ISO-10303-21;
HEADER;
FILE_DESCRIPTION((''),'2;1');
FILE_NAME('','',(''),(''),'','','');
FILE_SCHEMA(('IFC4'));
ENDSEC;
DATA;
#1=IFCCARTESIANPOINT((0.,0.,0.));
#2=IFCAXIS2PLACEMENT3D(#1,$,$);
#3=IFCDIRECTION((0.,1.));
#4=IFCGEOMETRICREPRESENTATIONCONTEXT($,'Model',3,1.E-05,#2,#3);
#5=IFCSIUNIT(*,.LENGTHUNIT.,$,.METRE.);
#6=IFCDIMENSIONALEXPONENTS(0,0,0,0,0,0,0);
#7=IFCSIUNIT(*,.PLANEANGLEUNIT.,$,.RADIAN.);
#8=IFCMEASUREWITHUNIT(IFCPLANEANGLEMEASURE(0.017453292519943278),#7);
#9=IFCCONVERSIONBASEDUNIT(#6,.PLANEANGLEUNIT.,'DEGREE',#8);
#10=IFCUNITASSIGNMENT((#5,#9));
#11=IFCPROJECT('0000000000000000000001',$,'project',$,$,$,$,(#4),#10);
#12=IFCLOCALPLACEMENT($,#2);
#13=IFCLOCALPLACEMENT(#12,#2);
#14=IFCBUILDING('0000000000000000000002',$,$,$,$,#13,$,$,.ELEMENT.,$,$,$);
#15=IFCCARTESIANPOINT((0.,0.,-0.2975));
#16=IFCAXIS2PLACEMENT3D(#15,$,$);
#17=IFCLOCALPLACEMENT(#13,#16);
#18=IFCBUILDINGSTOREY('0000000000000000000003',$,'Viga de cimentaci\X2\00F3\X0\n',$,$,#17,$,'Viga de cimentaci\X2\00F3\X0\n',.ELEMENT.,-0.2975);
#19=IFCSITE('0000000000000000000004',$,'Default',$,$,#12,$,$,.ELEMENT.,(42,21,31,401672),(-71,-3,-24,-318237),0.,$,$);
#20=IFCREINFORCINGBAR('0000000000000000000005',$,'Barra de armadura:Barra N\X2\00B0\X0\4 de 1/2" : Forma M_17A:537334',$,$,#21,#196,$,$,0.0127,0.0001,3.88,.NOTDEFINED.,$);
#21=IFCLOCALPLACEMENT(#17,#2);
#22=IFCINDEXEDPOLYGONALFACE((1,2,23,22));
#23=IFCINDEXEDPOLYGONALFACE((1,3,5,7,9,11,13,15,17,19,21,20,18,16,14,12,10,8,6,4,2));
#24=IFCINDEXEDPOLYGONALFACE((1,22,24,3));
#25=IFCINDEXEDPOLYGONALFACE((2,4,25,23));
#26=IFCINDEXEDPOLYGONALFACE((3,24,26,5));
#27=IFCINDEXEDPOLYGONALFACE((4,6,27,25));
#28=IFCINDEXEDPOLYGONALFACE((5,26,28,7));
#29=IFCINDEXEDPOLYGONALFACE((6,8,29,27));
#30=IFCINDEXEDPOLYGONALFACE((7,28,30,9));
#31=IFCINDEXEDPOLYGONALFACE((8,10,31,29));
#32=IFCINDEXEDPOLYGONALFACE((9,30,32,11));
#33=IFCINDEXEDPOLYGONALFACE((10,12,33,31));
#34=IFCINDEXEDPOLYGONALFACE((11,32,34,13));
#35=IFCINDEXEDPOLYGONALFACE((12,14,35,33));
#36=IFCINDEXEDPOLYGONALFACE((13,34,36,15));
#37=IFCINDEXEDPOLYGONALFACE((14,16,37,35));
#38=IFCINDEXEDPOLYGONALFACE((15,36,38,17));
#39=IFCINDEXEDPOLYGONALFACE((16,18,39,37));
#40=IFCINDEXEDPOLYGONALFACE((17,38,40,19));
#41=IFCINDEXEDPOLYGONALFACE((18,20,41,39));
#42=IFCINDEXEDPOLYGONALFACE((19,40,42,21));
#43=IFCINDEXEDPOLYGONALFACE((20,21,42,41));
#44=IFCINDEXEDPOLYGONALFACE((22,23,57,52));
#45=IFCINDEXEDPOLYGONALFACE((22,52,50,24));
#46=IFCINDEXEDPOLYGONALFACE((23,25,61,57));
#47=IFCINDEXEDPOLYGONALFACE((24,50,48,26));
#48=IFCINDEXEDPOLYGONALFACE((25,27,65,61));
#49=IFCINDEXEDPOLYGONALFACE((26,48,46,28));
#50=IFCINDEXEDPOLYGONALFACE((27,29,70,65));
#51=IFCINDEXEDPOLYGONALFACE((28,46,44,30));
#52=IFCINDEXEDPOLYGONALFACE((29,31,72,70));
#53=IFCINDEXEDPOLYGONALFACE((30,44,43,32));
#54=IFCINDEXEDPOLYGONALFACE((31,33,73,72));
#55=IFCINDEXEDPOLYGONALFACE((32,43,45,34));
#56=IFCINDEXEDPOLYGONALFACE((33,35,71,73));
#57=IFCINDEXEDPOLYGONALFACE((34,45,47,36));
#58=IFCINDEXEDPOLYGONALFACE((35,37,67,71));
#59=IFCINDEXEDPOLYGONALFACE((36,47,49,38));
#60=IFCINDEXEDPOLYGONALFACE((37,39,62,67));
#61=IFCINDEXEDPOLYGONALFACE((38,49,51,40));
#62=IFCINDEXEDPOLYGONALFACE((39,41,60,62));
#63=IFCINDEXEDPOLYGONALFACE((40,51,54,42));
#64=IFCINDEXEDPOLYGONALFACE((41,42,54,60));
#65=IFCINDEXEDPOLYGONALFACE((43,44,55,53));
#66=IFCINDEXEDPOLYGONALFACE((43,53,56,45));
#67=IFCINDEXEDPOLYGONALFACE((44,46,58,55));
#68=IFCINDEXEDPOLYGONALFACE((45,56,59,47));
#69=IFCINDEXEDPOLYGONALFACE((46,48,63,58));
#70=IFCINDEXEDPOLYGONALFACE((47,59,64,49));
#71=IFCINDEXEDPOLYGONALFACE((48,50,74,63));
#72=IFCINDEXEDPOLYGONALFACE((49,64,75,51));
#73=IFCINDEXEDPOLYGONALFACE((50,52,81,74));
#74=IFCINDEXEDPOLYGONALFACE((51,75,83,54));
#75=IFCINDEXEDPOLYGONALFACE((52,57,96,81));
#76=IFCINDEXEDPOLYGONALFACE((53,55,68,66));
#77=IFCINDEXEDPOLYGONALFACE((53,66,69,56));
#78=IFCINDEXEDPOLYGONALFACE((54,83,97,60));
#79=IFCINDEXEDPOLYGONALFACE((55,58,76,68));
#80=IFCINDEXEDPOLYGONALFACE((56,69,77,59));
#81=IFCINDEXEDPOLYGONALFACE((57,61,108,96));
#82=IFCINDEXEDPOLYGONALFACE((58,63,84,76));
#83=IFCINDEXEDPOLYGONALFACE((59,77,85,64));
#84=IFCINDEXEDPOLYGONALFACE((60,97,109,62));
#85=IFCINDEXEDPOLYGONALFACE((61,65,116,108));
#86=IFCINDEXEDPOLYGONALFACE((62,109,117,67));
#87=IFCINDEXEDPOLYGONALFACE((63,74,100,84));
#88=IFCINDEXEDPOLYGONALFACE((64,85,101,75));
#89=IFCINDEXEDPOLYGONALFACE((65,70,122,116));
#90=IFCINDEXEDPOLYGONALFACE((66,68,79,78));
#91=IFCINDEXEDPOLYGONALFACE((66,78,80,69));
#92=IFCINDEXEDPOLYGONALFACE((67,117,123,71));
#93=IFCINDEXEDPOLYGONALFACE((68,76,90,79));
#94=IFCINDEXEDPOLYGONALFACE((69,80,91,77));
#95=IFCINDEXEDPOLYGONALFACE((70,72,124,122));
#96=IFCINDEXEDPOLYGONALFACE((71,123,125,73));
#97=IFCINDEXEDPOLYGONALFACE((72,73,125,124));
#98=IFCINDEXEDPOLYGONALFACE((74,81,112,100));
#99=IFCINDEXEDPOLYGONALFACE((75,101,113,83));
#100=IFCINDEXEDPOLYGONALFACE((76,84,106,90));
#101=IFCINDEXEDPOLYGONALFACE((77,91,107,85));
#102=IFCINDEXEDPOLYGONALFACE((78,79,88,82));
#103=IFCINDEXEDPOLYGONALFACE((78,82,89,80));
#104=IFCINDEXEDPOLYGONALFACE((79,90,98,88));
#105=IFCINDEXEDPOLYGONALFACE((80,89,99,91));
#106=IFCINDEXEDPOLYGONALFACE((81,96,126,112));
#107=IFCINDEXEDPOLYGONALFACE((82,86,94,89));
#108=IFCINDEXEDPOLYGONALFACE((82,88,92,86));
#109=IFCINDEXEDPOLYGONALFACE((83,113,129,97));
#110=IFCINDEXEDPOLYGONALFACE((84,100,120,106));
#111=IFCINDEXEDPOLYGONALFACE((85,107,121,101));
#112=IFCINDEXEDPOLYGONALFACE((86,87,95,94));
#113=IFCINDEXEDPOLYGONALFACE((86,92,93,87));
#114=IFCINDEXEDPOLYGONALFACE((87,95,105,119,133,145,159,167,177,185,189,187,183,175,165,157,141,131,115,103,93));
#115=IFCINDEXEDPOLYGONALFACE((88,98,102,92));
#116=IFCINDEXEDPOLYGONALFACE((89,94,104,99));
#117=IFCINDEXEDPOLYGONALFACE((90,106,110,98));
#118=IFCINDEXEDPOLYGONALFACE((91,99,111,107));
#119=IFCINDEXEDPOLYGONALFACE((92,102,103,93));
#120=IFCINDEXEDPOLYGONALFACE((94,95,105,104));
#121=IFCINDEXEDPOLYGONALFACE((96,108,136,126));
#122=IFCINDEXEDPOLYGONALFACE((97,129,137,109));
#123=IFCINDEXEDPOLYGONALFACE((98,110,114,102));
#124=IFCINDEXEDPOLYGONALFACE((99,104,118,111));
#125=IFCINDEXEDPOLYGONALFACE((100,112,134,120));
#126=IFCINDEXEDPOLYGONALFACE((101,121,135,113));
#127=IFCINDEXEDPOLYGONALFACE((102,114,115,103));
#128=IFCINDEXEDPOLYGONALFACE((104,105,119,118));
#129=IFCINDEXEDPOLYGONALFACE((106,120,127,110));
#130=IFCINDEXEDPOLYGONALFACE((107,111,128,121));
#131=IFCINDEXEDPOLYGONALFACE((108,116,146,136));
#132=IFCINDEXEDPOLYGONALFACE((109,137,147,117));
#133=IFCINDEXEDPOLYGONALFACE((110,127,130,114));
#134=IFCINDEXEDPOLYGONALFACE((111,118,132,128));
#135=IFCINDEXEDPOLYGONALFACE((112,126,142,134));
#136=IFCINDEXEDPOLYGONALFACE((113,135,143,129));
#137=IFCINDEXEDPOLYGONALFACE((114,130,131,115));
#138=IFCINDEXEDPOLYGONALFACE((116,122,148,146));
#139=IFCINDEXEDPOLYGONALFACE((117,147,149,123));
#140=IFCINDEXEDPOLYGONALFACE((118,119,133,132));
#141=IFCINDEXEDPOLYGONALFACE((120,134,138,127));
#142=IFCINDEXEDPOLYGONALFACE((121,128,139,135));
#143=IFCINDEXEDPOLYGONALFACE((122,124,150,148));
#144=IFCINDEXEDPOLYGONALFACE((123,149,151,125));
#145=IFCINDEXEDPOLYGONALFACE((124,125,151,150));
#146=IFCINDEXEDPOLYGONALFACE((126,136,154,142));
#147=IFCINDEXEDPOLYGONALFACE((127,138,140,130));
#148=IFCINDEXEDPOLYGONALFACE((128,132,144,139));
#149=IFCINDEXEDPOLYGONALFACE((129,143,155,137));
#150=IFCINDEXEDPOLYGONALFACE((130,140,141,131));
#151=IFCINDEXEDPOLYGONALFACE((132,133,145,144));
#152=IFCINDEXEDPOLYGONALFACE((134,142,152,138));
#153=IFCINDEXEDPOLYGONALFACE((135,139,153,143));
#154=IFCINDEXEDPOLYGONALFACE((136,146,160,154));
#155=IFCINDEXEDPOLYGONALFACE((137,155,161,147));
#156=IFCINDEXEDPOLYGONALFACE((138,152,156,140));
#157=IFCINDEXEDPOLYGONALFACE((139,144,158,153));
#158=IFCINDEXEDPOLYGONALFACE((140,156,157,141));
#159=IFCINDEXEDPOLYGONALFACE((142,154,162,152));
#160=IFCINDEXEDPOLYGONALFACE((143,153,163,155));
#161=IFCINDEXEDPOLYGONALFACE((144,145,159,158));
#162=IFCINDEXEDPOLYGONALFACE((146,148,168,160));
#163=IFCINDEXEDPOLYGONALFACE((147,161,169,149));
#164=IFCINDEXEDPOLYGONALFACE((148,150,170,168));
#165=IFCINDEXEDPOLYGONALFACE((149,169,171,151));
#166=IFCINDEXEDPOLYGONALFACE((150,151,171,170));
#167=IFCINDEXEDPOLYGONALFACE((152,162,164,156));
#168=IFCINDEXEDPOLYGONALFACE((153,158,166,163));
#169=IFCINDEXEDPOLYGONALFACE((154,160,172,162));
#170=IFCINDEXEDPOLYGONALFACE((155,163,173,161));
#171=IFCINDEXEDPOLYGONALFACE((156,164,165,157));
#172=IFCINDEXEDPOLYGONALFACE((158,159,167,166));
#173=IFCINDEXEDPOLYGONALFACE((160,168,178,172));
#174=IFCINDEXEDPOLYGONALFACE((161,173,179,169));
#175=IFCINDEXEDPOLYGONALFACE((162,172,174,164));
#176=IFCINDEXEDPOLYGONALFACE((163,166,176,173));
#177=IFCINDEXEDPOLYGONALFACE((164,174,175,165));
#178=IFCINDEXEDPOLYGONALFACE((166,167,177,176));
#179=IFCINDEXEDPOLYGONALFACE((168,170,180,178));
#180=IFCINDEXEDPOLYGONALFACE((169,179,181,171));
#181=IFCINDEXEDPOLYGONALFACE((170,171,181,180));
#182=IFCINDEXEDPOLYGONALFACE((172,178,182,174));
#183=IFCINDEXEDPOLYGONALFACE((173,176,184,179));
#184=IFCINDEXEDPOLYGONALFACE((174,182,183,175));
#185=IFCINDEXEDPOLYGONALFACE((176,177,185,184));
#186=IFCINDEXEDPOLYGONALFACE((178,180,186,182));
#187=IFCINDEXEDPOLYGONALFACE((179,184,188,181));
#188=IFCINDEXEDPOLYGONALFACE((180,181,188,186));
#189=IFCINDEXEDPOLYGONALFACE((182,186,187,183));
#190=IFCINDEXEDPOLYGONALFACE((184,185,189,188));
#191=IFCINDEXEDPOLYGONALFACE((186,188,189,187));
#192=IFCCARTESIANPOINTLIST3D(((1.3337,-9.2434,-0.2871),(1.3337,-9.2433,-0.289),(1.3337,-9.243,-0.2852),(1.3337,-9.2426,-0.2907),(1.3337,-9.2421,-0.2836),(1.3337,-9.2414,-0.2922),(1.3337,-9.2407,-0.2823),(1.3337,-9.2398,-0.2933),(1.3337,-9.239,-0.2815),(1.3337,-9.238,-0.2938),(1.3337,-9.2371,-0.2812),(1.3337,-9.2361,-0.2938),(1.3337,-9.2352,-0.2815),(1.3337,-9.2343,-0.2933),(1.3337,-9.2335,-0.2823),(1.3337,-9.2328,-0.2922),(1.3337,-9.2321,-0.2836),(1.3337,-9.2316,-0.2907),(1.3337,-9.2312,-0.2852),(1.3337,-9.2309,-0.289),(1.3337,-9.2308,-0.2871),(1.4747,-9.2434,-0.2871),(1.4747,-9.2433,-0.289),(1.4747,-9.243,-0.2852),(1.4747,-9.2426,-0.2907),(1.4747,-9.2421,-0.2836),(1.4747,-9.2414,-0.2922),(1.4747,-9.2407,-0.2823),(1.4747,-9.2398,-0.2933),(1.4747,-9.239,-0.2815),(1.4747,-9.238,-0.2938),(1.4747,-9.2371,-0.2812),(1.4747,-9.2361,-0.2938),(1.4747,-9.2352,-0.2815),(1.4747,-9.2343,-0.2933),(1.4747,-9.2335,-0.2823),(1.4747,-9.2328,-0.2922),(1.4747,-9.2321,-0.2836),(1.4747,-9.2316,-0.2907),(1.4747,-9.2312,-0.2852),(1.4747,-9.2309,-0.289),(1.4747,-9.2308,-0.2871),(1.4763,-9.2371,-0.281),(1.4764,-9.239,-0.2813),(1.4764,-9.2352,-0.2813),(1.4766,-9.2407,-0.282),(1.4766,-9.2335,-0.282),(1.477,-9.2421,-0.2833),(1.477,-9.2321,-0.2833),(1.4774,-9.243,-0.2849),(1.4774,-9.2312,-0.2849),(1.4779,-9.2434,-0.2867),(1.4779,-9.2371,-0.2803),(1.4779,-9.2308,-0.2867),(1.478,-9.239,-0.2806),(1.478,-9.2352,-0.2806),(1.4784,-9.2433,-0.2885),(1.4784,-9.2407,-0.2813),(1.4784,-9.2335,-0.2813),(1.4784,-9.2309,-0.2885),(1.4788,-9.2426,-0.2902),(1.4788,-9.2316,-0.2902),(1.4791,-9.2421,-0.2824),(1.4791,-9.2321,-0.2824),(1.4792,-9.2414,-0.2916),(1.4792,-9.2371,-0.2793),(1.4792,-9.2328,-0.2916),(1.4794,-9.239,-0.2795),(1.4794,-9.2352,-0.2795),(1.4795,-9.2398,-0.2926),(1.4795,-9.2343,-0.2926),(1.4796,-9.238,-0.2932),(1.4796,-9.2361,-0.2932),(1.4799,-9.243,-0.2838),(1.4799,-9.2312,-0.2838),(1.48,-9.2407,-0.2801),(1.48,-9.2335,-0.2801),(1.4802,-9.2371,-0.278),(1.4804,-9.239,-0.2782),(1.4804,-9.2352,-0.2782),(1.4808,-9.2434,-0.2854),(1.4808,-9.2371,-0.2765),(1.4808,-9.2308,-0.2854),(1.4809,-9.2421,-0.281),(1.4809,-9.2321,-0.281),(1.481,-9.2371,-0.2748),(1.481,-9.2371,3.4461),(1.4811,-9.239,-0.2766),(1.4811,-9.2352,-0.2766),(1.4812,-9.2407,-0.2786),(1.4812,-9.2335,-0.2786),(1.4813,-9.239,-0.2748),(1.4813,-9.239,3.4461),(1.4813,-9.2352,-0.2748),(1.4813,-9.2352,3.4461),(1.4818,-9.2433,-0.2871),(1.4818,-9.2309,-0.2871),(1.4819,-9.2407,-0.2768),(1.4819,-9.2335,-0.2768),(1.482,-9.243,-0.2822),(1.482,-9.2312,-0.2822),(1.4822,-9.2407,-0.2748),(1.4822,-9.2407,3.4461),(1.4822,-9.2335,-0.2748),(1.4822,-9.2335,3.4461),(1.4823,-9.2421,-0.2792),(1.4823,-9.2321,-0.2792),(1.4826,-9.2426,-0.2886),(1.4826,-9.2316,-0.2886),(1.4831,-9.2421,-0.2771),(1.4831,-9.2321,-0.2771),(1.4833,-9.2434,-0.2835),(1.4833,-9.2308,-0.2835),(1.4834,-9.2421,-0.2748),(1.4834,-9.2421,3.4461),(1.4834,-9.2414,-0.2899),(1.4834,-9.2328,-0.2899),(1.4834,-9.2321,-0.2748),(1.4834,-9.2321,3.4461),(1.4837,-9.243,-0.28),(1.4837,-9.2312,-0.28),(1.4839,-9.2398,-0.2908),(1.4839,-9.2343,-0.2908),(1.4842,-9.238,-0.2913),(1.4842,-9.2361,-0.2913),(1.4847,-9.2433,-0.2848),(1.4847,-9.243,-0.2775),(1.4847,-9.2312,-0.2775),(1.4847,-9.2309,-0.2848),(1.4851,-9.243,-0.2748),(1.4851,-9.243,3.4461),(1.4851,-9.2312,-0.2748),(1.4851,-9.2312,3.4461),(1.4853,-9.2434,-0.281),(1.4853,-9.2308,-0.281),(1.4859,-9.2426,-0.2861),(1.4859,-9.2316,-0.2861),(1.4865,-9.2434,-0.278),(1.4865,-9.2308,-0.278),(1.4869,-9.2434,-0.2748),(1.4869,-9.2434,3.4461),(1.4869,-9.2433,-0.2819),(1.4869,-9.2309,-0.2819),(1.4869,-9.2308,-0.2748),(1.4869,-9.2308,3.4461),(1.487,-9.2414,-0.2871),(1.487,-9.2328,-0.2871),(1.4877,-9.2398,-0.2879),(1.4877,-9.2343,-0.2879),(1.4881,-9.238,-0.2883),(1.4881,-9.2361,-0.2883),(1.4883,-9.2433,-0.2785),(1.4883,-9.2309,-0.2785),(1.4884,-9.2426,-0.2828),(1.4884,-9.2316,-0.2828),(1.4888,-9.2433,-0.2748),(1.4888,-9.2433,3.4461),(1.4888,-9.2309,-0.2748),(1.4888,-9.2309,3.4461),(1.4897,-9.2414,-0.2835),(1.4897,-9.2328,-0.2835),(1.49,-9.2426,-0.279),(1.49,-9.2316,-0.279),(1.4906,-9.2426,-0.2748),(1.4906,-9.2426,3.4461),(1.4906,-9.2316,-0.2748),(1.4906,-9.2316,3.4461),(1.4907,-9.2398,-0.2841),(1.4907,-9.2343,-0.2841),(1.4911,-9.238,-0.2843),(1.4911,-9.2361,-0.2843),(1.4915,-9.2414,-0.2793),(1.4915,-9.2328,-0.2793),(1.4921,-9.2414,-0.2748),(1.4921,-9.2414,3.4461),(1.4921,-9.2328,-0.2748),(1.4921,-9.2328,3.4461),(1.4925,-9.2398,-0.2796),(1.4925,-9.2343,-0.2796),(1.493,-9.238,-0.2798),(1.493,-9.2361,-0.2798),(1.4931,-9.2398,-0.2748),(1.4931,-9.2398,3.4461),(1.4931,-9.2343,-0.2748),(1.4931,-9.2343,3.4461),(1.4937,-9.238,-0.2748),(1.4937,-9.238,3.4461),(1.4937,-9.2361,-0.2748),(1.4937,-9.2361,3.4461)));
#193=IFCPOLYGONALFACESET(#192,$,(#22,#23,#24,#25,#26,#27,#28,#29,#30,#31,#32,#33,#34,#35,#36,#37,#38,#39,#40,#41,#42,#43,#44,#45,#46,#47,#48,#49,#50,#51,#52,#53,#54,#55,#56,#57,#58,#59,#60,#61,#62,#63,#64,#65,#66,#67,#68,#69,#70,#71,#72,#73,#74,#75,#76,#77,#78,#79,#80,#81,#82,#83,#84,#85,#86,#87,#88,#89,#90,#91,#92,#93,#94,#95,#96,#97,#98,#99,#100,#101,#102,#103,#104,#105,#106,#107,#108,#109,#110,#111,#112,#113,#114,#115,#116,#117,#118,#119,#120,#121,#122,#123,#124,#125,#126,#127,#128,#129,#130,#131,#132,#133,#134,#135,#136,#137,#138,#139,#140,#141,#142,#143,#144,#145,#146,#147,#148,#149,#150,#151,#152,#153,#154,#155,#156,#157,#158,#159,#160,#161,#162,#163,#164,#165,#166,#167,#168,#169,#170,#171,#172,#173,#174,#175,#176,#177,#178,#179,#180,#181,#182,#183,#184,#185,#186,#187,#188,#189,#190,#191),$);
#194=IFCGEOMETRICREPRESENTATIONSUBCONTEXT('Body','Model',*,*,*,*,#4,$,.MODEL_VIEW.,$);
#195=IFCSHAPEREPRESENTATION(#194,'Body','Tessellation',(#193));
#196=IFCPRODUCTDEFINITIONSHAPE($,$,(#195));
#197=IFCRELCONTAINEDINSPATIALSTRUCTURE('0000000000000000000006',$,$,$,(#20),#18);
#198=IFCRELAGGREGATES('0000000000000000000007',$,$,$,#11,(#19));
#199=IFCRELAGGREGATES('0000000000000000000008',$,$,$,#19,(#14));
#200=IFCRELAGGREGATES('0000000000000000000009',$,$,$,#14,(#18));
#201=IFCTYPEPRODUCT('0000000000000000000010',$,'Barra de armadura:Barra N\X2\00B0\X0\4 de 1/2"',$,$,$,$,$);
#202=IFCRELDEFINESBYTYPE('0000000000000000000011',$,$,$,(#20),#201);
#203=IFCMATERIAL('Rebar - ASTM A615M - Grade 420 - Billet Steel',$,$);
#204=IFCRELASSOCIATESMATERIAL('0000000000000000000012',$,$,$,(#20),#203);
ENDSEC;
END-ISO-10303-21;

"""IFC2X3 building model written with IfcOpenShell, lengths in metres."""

from ifc_helpers import new_model, entity, si_unit, converted_unit, direction, frame, origin, place, context, subcontext, project, spatial, material, type_object, element, save


model = new_model("IFC2X3")

# Units and contexts
model_context = context("Model", 3, precision=1e-05, world=origin(), true_north=direction((0.0, 1.0)))
body_context = subcontext(model_context, "Body", "Model", "MODEL_VIEW")
ifc_project = project(units=[si_unit("LENGTHUNIT", "METRE"), converted_unit("PLANEANGLEUNIT", "DEGREE", entity("IfcPlaneAngleMeasure", 0.017453292519943278), si_unit("PLANEANGLEUNIT", "RADIAN"), dimensions=[0, 0, 0, 0, 0, 0, 0])], contexts=[model_context])

# Site, building, storey
site_placement = place(None, origin())
site = spatial("IfcSite", under=ifc_project, at=site_placement, Name="Default", CompositionType="ELEMENT", RefLatitude=(42, 21, 31, 401672), RefLongitude=(-71, -3, -24, -318237), RefElevation=0.0)
building_placement = place(site_placement, origin())
building = spatial("IfcBuilding", under=site, at=building_placement, CompositionType="ELEMENT")
storey_placement = place(building_placement, frame((0.0, 0.0, -0.2975)))
storey = spatial("IfcBuildingStorey", under=building, at=storey_placement, Name="Viga de cimentación", LongName="Viga de cimentación", CompositionType="ELEMENT", Elevation=-0.2975)

# Reinforcing bar
ifc_material = material(Name="Rebar - ASTM A615M - Grade 420 - Billet Steel")
type_product_1 = type_object("IfcTypeProduct", Name="Barra de armadura:Barra N°4 de 1/2\"")
reinforcing_bar_1_placement = place(storey_placement, origin())
element("IfcReinforcingBar", 1, at=reinforcing_bar_1_placement, inside=storey, type_object=type_product_1, material=ifc_material, Name="Barra de armadura:Barra N°4 de 1/2\" : Forma M_17A:537334", BarLength=3.88, BarRole="NOTDEFINED", CrossSectionArea=0.0001, NominalDiameter=0.0127, context=body_context, shape_type="AdvancedSweptSolid", body=[
    entity("IfcSweptDiskSolid", entity("IfcCompositeCurve", [entity("IfcCompositeCurveSegment", "CONTINUOUS", True, entity("IfcPolyline", [entity("IfcCartesianPoint", [1.4874, -9.2371, 3.4461]), entity("IfcCartesianPoint", [1.4874, -9.2371, -0.2748])])), entity("IfcCompositeCurveSegment", "CONTINUOUS", True, entity("IfcTrimmedCurve", entity("IfcCircle", entity("IfcAxis2Placement3D", entity("IfcCartesianPoint", [1.4747, -9.2371, -0.2748]), entity("IfcDirection", [0.0, 1.0, 0.0]), entity("IfcDirection", [0.0, 0.0, -1.0])), 0.0127), [entity("IfcParameterValue", 270.0)], [entity("IfcParameterValue", 360.0)], True, "PARAMETER")), entity("IfcCompositeCurveSegment", "CONTINUOUS", True, entity("IfcPolyline", [entity("IfcCartesianPoint", [1.4747, -9.2371, -0.2875]), entity("IfcCartesianPoint", [1.3337, -9.2371, -0.2875])]))], False), 0.0063, None, 0.0, 92.0),
])

save(model, "model.ifc")
